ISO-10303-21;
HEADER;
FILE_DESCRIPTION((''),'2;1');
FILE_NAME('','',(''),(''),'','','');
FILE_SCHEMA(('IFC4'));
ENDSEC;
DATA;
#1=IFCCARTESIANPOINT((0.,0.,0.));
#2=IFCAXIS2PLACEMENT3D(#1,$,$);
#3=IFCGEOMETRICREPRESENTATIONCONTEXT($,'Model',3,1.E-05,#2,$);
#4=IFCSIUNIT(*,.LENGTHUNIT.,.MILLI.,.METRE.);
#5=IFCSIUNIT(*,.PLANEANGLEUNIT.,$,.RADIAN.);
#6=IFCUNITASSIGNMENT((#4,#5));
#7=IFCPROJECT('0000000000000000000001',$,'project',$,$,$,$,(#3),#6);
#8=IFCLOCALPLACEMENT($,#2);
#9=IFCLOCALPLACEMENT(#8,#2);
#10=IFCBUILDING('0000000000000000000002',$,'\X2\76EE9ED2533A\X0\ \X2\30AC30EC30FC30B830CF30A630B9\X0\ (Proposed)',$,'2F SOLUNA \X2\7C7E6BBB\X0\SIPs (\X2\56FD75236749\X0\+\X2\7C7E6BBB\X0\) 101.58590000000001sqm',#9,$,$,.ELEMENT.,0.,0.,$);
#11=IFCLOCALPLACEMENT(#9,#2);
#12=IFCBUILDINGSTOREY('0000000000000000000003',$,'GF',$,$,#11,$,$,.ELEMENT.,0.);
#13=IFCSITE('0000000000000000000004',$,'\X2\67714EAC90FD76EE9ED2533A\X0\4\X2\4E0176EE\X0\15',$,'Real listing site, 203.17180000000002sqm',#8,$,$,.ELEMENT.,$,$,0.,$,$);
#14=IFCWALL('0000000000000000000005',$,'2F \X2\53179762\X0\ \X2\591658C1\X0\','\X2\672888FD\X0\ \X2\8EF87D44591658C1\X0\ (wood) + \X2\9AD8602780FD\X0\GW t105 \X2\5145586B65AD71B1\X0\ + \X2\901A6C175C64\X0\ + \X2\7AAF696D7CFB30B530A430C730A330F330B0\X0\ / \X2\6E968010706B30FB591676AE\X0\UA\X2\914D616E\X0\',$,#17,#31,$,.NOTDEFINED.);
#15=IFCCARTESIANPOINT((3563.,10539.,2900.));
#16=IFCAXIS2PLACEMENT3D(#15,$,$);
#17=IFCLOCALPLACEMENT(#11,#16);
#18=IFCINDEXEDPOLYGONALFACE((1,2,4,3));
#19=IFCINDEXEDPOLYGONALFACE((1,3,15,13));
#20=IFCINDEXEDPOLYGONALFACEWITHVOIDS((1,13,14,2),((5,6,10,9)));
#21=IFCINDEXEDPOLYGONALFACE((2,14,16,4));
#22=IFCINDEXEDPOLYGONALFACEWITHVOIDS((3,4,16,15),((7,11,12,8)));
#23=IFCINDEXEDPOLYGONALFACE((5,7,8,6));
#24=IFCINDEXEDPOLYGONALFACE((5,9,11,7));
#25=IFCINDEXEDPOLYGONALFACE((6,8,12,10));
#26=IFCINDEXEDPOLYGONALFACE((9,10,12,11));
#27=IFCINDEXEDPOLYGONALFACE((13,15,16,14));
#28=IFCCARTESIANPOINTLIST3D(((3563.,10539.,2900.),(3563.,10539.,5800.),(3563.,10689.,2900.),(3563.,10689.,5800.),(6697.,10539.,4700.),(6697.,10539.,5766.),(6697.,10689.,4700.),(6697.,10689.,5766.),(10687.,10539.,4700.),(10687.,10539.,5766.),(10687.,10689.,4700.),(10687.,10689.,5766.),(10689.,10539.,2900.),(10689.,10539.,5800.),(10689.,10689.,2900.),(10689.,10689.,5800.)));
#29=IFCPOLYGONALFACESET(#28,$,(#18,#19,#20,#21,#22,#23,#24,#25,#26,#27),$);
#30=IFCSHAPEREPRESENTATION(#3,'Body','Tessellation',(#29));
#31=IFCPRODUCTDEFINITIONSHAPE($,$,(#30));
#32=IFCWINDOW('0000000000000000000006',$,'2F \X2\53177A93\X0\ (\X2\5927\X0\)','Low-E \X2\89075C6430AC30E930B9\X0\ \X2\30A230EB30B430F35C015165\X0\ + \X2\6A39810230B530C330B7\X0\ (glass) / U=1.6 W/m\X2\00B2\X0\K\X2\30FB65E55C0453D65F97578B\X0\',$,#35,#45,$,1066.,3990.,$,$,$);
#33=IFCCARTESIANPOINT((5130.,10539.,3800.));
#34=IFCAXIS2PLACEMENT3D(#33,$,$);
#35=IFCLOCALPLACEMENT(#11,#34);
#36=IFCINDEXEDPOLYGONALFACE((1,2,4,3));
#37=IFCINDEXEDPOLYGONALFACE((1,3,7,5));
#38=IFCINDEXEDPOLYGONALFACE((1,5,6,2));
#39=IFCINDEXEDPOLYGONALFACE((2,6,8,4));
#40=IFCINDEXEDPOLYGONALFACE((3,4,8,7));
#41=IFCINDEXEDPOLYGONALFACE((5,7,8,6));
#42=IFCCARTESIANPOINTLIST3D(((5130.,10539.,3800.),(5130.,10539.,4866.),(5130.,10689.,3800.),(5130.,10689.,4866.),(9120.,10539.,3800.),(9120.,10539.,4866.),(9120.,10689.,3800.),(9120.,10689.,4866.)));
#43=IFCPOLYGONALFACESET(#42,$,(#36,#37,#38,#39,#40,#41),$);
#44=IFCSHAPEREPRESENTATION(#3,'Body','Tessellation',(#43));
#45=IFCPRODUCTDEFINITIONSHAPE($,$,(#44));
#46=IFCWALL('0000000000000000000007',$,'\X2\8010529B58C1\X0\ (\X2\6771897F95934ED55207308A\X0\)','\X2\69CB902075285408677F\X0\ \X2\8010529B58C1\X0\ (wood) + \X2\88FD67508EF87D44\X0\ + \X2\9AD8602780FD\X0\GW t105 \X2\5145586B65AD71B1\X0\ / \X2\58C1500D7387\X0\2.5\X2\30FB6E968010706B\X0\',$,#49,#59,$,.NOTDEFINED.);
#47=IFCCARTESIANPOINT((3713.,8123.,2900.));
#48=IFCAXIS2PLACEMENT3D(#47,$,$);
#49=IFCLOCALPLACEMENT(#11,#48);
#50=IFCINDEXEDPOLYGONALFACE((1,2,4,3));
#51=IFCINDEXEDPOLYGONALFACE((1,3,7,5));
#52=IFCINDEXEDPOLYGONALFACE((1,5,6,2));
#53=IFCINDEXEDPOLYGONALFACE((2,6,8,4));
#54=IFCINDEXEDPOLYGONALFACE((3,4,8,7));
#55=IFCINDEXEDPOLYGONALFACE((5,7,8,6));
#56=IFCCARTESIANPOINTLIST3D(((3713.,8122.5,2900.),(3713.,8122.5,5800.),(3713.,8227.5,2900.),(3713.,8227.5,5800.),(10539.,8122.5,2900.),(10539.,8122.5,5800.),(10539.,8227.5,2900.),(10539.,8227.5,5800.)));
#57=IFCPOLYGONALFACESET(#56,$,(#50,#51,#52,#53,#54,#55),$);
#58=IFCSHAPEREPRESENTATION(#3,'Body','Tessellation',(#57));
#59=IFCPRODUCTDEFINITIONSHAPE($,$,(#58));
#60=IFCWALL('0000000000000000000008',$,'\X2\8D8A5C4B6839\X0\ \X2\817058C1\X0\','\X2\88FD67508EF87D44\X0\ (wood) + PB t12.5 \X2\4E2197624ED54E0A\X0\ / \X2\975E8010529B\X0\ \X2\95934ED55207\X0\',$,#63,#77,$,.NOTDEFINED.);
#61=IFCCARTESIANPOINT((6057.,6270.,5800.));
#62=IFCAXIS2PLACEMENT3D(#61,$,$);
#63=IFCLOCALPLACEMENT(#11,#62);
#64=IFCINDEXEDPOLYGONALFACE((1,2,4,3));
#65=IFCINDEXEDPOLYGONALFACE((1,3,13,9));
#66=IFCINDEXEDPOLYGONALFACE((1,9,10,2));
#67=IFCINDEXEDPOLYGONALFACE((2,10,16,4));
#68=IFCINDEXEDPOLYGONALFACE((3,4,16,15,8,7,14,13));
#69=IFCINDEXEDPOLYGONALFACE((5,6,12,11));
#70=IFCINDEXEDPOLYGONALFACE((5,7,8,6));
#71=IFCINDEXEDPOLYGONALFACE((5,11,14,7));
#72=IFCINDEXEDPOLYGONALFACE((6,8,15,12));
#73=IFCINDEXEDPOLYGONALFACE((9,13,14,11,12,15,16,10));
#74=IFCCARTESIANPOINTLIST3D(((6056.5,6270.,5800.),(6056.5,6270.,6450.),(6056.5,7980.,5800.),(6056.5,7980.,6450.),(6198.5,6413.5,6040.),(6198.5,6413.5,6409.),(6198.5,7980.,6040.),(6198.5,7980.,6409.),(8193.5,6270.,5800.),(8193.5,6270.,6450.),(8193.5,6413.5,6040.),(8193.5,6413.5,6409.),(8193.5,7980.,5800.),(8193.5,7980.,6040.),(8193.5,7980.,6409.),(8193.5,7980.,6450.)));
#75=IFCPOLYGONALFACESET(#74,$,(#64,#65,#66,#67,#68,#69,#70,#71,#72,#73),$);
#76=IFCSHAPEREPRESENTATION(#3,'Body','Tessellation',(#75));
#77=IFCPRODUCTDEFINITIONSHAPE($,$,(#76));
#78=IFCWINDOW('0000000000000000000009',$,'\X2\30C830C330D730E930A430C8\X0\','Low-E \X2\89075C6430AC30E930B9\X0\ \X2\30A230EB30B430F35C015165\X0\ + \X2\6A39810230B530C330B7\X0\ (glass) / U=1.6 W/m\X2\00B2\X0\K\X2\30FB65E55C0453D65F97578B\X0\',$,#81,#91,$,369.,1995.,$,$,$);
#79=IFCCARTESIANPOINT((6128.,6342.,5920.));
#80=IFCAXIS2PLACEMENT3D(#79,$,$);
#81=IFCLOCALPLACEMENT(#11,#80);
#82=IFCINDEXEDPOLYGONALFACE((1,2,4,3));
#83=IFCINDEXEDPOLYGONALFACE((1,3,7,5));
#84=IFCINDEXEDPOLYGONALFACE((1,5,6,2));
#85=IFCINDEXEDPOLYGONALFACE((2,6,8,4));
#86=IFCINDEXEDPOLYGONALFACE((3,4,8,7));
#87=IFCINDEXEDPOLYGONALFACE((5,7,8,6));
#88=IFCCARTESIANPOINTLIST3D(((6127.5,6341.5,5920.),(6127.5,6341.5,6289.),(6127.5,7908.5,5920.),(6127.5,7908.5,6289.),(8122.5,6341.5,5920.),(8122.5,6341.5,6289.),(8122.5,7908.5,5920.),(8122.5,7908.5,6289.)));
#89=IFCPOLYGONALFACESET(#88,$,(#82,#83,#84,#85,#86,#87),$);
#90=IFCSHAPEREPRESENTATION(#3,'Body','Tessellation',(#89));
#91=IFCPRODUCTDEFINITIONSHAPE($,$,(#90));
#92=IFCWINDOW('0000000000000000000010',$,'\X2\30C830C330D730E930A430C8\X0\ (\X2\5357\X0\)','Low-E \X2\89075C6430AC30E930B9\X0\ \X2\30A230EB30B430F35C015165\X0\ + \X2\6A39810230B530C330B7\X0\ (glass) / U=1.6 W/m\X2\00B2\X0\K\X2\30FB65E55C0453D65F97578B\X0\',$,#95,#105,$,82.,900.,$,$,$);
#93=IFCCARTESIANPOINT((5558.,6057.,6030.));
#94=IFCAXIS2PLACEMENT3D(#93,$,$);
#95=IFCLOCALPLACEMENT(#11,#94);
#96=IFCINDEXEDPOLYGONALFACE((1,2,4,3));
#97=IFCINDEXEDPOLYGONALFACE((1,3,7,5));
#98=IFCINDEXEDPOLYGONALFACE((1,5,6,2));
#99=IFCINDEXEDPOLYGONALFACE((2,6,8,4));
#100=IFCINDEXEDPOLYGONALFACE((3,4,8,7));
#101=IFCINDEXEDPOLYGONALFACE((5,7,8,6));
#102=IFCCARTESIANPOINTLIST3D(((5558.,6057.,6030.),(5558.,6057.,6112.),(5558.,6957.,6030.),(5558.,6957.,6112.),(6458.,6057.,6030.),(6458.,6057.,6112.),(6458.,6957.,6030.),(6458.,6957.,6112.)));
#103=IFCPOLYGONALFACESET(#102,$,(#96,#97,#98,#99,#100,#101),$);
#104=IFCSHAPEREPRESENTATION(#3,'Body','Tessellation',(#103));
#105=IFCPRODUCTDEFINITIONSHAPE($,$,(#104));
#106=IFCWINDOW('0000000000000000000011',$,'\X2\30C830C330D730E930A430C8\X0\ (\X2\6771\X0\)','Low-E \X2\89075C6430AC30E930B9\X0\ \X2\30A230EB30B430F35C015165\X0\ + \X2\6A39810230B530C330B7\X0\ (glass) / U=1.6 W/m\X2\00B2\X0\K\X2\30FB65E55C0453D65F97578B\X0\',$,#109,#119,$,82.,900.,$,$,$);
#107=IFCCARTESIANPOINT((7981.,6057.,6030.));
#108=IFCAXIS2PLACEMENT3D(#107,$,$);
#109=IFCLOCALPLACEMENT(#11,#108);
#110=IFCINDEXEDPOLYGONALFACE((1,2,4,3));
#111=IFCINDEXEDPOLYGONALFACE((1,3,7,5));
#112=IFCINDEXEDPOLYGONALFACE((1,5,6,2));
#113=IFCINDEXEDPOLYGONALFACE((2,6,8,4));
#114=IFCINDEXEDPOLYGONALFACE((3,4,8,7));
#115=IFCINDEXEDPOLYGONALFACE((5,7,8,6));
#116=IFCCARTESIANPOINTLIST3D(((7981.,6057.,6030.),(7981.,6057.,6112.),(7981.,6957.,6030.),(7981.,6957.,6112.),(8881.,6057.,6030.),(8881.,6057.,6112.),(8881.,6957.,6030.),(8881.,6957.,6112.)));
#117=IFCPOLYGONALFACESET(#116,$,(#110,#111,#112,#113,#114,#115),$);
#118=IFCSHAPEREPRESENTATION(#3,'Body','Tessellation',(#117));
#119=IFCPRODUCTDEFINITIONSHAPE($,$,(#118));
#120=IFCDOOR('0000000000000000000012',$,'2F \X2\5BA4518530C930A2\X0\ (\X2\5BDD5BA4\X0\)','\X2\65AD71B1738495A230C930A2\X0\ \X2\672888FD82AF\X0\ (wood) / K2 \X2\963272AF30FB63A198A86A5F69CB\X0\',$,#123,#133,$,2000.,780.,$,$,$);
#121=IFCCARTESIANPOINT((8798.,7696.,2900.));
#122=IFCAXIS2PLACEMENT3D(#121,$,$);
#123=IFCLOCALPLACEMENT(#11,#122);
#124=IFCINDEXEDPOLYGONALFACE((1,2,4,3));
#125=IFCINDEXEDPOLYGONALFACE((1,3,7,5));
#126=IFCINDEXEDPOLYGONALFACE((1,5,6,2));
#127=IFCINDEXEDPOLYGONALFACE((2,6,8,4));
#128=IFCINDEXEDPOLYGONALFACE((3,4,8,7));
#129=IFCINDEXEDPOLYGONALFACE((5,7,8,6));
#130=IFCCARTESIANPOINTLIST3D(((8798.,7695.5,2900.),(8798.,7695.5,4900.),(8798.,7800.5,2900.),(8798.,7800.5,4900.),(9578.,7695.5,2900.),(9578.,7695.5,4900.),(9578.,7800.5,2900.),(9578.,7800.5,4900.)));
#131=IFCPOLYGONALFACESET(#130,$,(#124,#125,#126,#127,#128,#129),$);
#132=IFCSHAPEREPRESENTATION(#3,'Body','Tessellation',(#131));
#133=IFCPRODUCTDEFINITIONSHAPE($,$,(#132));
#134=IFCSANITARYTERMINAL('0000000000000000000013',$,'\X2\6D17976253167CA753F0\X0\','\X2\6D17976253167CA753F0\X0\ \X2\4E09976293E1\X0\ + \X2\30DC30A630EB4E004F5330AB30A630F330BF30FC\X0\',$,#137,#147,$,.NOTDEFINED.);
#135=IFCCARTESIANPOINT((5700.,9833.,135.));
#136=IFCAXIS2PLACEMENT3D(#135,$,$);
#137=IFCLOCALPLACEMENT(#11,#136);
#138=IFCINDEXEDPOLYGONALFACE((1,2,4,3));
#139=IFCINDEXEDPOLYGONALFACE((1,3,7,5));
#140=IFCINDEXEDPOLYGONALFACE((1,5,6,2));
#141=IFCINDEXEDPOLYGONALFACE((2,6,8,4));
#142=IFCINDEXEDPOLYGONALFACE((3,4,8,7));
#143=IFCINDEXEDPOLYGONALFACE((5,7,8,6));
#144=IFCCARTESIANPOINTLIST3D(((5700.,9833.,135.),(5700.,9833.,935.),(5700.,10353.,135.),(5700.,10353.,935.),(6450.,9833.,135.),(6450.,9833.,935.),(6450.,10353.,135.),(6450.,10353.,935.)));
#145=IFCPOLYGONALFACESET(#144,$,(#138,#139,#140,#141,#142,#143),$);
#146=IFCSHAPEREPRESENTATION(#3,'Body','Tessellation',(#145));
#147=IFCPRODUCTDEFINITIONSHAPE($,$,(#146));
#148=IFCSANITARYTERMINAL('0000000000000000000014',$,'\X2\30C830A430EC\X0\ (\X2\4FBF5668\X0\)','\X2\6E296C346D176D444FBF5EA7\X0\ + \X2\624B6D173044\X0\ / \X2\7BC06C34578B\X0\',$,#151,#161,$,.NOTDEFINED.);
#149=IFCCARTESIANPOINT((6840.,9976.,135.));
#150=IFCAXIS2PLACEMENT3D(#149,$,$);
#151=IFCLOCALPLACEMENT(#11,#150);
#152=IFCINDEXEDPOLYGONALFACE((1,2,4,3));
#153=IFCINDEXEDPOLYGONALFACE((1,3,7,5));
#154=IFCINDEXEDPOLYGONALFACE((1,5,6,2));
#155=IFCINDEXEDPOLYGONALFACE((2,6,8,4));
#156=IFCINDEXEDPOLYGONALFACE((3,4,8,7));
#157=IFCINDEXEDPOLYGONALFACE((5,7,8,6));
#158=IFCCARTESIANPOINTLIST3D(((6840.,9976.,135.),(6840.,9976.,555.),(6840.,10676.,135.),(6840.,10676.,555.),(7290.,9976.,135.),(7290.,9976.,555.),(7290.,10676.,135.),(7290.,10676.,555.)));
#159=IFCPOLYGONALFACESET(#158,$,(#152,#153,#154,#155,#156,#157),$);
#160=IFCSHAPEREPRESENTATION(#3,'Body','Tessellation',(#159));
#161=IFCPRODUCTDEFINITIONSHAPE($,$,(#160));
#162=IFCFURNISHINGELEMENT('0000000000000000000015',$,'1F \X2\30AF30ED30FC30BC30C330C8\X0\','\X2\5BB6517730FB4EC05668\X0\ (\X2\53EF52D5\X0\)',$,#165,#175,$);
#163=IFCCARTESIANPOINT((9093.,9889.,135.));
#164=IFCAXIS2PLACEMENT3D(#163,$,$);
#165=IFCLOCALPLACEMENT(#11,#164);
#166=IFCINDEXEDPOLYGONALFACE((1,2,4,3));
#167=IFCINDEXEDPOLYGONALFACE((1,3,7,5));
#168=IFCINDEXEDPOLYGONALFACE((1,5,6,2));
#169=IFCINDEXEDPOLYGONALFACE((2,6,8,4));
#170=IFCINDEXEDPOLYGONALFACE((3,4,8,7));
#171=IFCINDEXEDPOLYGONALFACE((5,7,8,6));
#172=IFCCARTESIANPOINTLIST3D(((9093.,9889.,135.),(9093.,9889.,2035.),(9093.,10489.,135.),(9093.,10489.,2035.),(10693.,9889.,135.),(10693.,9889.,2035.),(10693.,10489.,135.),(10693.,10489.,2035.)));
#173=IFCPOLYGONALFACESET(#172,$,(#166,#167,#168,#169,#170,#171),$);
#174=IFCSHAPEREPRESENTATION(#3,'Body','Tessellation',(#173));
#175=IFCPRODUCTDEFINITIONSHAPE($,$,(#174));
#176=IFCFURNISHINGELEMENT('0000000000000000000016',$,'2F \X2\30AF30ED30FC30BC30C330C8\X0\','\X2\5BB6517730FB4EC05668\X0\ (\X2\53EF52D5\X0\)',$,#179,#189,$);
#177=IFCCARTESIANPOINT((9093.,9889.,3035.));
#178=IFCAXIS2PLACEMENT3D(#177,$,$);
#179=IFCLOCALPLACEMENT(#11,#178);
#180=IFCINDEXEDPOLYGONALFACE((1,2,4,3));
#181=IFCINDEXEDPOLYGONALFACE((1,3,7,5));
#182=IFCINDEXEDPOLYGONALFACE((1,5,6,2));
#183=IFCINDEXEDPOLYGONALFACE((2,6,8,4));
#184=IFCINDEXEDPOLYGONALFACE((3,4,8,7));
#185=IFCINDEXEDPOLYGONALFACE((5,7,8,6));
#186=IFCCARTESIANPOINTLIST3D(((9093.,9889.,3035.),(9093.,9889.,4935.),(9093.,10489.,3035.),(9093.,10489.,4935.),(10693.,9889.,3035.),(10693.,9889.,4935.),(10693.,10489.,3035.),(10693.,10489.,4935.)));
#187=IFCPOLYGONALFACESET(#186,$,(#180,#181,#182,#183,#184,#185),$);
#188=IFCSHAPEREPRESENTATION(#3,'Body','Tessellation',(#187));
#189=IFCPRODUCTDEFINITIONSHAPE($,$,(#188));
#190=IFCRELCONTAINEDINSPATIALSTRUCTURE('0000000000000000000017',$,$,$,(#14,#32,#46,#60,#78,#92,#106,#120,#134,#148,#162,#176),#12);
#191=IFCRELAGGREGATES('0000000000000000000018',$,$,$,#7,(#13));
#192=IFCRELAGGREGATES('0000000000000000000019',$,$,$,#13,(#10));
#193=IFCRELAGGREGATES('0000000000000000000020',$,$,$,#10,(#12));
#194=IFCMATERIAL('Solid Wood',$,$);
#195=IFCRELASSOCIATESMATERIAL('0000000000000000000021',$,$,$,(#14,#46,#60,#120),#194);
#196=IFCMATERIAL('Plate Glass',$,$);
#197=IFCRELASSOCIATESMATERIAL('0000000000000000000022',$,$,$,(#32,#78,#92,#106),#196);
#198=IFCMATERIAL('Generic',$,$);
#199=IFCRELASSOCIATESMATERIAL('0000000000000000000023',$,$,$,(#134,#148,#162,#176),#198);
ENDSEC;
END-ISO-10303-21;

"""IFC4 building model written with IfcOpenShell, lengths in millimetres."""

from ifc_helpers import new_model, si_unit, frame, frame_2d, origin, place, context, project, spatial, rectangle, extrude, material, element, fill, save


model = new_model("IFC4")

# Units and contexts
model_context = context("Model", 3, precision=1e-05, world=origin())
ifc_project = project(units=[si_unit("LENGTHUNIT", "METRE", prefix="MILLI"), si_unit("PLANEANGLEUNIT", "RADIAN")], contexts=[model_context])

# Site, building, storey
site_placement = place(None, origin())
site = spatial("IfcSite", under=ifc_project, at=site_placement, Name="東京都目黒区4丁目15", ObjectType="Real listing site, 203.17180000000002sqm", CompositionType="ELEMENT", RefElevation=0.0)
building_placement = place(site_placement, origin())
building = spatial("IfcBuilding", under=site, at=building_placement, Name="目黒区 ガレージハウス (Proposed)", ObjectType="2F SOLUNA 籾殻SIPs (国産杉+籾殻) 101.58590000000001sqm", CompositionType="ELEMENT", ElevationOfRefHeight=0.0, ElevationOfTerrain=0.0)
storey_placement = place(building_placement, origin())
storey = spatial("IfcBuildingStorey", under=building, at=storey_placement, Name="GF", CompositionType="ELEMENT", Elevation=0.0)

# Wall, opening, window
ifc_material_1 = material(Name="Solid Wood")
wall_1_placement = place(storey_placement, frame((3563.0, 10539.0, 2900.0)))
wall_1 = element("IfcWall", 1, at=wall_1_placement, inside=storey, material=ifc_material_1, Name="2F 北面 外壁", Description="木製 軸組外壁 (wood) + 高性能GW t105 充填断熱 + 通気層 + 窯業系サイディング / 準耐火・外皮UA配慮", PredefinedType="NOTDEFINED", context=model_context, shape_type="SweptSolid", body=[
    extrude(rectangle(XDim=7126.0, YDim=150.0, at=frame_2d((3563.0, 75.0))), frame((3563.0, 10539.0, 2900.0)), (0.0, 0.0, 1.0), 2900.0),
])
opening_1_placement = place(storey_placement, frame((5130.0, 10539.0, 3800.0)))
opening_1 = element("IfcOpeningElement", 2, at=opening_1_placement, cuts=wall_1, PredefinedType="NOTDEFINED", context=model_context, shape_type="SweptSolid", body=[
    extrude(rectangle(XDim=3990.0, YDim=150.0, at=frame_2d((1995.0, 75.0))), frame((5130.0, 10539.0, 3800.0)), (0.0, 0.0, 1.0), 1066.0),
])
ifc_material_2 = material(Name="Plate Glass")
window_1_placement = place(storey_placement, frame((5130.0, 10539.0, 3800.0)))
window_1 = element("IfcWindow", 3, at=window_1_placement, inside=storey, material=ifc_material_2, Name="2F 北窓 (大)", Description="Low-E 複層ガラス アルゴン封入 + 樹脂サッシ (glass) / U=1.6 W/m²K・日射取得型", OverallHeight=1066.0, OverallWidth=3990.0, context=model_context, shape_type="SweptSolid", body=[
    extrude(rectangle(XDim=3990.0, YDim=150.0, at=frame_2d((1995.0, 75.0))), frame((5130.0, 10539.0, 3800.0)), (0.0, 0.0, 1.0), 1066.0),
])
fill(opening_1, window_1)

# Wall
wall_2_placement = place(storey_placement, frame((3713.0, 8123.0, 2900.0)))
element("IfcWall", 4, at=wall_2_placement, inside=storey, material=ifc_material_1, Name="耐力壁 (東西間仕切り)", Description="構造用合板 耐力壁 (wood) + 製材軸組 + 高性能GW t105 充填断熱 / 壁倍率2.5・準耐火", PredefinedType="NOTDEFINED", context=model_context, shape_type="SweptSolid", body=[
    extrude(rectangle(XDim=6826.0, YDim=105.0, at=frame_2d((3413.0, 52.0))), frame((3713.0, 8123.0, 2900.0)), (0.0, 0.0, 1.0), 2900.0),
])

# Wall, openings, windows
wall_3_placement = place(storey_placement, frame((6057.0, 6270.0, 5800.0)))
wall_3 = element("IfcWall", 5, at=wall_3_placement, inside=storey, material=ifc_material_1, Name="越屋根 腰壁", Description="製材軸組 (wood) + PB t12.5 両面仕上 / 非耐力 間仕切", PredefinedType="NOTDEFINED", context=model_context, shape_type="SweptSolid", body=[
    extrude(rectangle(XDim=2137.0, YDim=1710.0, at=frame_2d((1068.0, 855.0))), frame((6057.0, 6270.0, 5800.0)), (0.0, 0.0, 1.0), 650.0),
])
opening_2_placement = place(storey_placement, frame((6128.0, 6342.0, 5920.0)))
opening_2 = element("IfcOpeningElement", 6, at=opening_2_placement, cuts=wall_3, PredefinedType="NOTDEFINED", context=model_context, shape_type="SweptSolid", body=[
    extrude(rectangle(XDim=1995.0, YDim=1567.0, at=frame_2d((997.0, 783.0))), frame((6128.0, 6342.0, 5920.0)), (0.0, 0.0, 1.0), 369.0),
])
opening_3_placement = place(storey_placement, frame((5558.0, 6057.0, 6030.0)))
opening_3 = element("IfcOpeningElement", 7, at=opening_3_placement, cuts=wall_3, PredefinedType="NOTDEFINED", context=model_context, shape_type="SweptSolid", body=[
    extrude(rectangle(XDim=900.0, YDim=900.0, at=frame_2d((450.0, 450.0))), frame((5558.0, 6057.0, 6030.0)), (0.0, 0.0, 1.0), 82.0),
])
opening_4_placement = place(storey_placement, frame((7981.0, 6057.0, 6030.0)))
opening_4 = element("IfcOpeningElement", 8, at=opening_4_placement, cuts=wall_3, PredefinedType="NOTDEFINED", context=model_context, shape_type="SweptSolid", body=[
    extrude(rectangle(XDim=900.0, YDim=900.0, at=frame_2d((450.0, 450.0))), frame((7981.0, 6057.0, 6030.0)), (0.0, 0.0, 1.0), 82.0),
])
window_2_placement = place(storey_placement, frame((6128.0, 6342.0, 5920.0)))
window_2 = element("IfcWindow", 9, at=window_2_placement, inside=storey, material=ifc_material_2, Name="トップライト", Description="Low-E 複層ガラス アルゴン封入 + 樹脂サッシ (glass) / U=1.6 W/m²K・日射取得型", OverallHeight=369.0, OverallWidth=1995.0, context=model_context, shape_type="SweptSolid", body=[
    extrude(rectangle(XDim=1995.0, YDim=1567.0, at=frame_2d((997.0, 783.0))), frame((6128.0, 6342.0, 5920.0)), (0.0, 0.0, 1.0), 369.0),
])
fill(opening_2, window_2)
window_3_placement = place(storey_placement, frame((5558.0, 6057.0, 6030.0)))
window_3 = element("IfcWindow", 10, at=window_3_placement, inside=storey, material=ifc_material_2, Name="トップライト (南)", Description="Low-E 複層ガラス アルゴン封入 + 樹脂サッシ (glass) / U=1.6 W/m²K・日射取得型", OverallHeight=82.0, OverallWidth=900.0, context=model_context, shape_type="SweptSolid", body=[
    extrude(rectangle(XDim=900.0, YDim=900.0, at=frame_2d((450.0, 450.0))), frame((5558.0, 6057.0, 6030.0)), (0.0, 0.0, 1.0), 82.0),
])
fill(opening_3, window_3)
window_4_placement = place(storey_placement, frame((7981.0, 6057.0, 6030.0)))
window_4 = element("IfcWindow", 11, at=window_4_placement, inside=storey, material=ifc_material_2, Name="トップライト (東)", Description="Low-E 複層ガラス アルゴン封入 + 樹脂サッシ (glass) / U=1.6 W/m²K・日射取得型", OverallHeight=82.0, OverallWidth=900.0, context=model_context, shape_type="SweptSolid", body=[
    extrude(rectangle(XDim=900.0, YDim=900.0, at=frame_2d((450.0, 450.0))), frame((7981.0, 6057.0, 6030.0)), (0.0, 0.0, 1.0), 82.0),
])
fill(opening_4, window_4)

# Door
door_placement = place(storey_placement, frame((8798.0, 7696.0, 2900.0)))
element("IfcDoor", 12, at=door_placement, inside=storey, material=ifc_material_1, Name="2F 室内ドア (寝室)", Description="断熱玄関ドア 木製芯 (wood) / K2 防犯・採風機構", OverallHeight=2000.0, OverallWidth=780.0, context=model_context, shape_type="SweptSolid", body=[
    extrude(rectangle(XDim=780.0, YDim=105.0, at=frame_2d((390.0, 52.0))), frame((8798.0, 7696.0, 2900.0)), (0.0, 0.0, 1.0), 2000.0),
])

# Sanitary terminals
ifc_material_3 = material(Name="Generic")
sanitary_terminal_1_placement = place(storey_placement, frame((5700.0, 9833.0, 135.0)))
element("IfcSanitaryTerminal", 13, at=sanitary_terminal_1_placement, inside=storey, material=ifc_material_3, Name="洗面化粧台", Description="洗面化粧台 三面鏡 + ボウル一体カウンター", PredefinedType="NOTDEFINED", context=model_context, shape_type="SweptSolid", body=[
    extrude(rectangle(XDim=750.0, YDim=520.0, at=frame_2d((375.0, 260.0))), frame((5700.0, 9833.0, 135.0)), (0.0, 0.0, 1.0), 800.0),
])
sanitary_terminal_2_placement = place(storey_placement, frame((6840.0, 9976.0, 135.0)))
element("IfcSanitaryTerminal", 14, at=sanitary_terminal_2_placement, inside=storey, material=ifc_material_3, Name="トイレ (便器)", Description="温水洗浄便座 + 手洗い / 節水型", PredefinedType="NOTDEFINED", context=model_context, shape_type="SweptSolid", body=[
    extrude(rectangle(XDim=450.0, YDim=700.0, at=frame_2d((225.0, 350.0))), frame((6840.0, 9976.0, 135.0)), (0.0, 0.0, 1.0), 420.0),
])

# Furnishing elements
furnishing_1_placement = place(storey_placement, frame((9093.0, 9889.0, 135.0)))
element("IfcFurnishingElement", 15, at=furnishing_1_placement, inside=storey, material=ifc_material_3, Name="1F クローゼット", Description="家具・什器 (可動)", context=model_context, shape_type="SweptSolid", body=[
    extrude(rectangle(XDim=1600.0, YDim=600.0, at=frame_2d((800.0, 300.0))), frame((9093.0, 9889.0, 135.0)), (0.0, 0.0, 1.0), 1900.0),
])
furnishing_2_placement = place(storey_placement, frame((9093.0, 9889.0, 3035.0)))
element("IfcFurnishingElement", 16, at=furnishing_2_placement, inside=storey, material=ifc_material_3, Name="2F クローゼット", Description="家具・什器 (可動)", context=model_context, shape_type="SweptSolid", body=[
    extrude(rectangle(XDim=1600.0, YDim=600.0, at=frame_2d((800.0, 300.0))), frame((9093.0, 9889.0, 3035.0)), (0.0, 0.0, 1.0), 1900.0),
])

save(model, "model.ifc")
